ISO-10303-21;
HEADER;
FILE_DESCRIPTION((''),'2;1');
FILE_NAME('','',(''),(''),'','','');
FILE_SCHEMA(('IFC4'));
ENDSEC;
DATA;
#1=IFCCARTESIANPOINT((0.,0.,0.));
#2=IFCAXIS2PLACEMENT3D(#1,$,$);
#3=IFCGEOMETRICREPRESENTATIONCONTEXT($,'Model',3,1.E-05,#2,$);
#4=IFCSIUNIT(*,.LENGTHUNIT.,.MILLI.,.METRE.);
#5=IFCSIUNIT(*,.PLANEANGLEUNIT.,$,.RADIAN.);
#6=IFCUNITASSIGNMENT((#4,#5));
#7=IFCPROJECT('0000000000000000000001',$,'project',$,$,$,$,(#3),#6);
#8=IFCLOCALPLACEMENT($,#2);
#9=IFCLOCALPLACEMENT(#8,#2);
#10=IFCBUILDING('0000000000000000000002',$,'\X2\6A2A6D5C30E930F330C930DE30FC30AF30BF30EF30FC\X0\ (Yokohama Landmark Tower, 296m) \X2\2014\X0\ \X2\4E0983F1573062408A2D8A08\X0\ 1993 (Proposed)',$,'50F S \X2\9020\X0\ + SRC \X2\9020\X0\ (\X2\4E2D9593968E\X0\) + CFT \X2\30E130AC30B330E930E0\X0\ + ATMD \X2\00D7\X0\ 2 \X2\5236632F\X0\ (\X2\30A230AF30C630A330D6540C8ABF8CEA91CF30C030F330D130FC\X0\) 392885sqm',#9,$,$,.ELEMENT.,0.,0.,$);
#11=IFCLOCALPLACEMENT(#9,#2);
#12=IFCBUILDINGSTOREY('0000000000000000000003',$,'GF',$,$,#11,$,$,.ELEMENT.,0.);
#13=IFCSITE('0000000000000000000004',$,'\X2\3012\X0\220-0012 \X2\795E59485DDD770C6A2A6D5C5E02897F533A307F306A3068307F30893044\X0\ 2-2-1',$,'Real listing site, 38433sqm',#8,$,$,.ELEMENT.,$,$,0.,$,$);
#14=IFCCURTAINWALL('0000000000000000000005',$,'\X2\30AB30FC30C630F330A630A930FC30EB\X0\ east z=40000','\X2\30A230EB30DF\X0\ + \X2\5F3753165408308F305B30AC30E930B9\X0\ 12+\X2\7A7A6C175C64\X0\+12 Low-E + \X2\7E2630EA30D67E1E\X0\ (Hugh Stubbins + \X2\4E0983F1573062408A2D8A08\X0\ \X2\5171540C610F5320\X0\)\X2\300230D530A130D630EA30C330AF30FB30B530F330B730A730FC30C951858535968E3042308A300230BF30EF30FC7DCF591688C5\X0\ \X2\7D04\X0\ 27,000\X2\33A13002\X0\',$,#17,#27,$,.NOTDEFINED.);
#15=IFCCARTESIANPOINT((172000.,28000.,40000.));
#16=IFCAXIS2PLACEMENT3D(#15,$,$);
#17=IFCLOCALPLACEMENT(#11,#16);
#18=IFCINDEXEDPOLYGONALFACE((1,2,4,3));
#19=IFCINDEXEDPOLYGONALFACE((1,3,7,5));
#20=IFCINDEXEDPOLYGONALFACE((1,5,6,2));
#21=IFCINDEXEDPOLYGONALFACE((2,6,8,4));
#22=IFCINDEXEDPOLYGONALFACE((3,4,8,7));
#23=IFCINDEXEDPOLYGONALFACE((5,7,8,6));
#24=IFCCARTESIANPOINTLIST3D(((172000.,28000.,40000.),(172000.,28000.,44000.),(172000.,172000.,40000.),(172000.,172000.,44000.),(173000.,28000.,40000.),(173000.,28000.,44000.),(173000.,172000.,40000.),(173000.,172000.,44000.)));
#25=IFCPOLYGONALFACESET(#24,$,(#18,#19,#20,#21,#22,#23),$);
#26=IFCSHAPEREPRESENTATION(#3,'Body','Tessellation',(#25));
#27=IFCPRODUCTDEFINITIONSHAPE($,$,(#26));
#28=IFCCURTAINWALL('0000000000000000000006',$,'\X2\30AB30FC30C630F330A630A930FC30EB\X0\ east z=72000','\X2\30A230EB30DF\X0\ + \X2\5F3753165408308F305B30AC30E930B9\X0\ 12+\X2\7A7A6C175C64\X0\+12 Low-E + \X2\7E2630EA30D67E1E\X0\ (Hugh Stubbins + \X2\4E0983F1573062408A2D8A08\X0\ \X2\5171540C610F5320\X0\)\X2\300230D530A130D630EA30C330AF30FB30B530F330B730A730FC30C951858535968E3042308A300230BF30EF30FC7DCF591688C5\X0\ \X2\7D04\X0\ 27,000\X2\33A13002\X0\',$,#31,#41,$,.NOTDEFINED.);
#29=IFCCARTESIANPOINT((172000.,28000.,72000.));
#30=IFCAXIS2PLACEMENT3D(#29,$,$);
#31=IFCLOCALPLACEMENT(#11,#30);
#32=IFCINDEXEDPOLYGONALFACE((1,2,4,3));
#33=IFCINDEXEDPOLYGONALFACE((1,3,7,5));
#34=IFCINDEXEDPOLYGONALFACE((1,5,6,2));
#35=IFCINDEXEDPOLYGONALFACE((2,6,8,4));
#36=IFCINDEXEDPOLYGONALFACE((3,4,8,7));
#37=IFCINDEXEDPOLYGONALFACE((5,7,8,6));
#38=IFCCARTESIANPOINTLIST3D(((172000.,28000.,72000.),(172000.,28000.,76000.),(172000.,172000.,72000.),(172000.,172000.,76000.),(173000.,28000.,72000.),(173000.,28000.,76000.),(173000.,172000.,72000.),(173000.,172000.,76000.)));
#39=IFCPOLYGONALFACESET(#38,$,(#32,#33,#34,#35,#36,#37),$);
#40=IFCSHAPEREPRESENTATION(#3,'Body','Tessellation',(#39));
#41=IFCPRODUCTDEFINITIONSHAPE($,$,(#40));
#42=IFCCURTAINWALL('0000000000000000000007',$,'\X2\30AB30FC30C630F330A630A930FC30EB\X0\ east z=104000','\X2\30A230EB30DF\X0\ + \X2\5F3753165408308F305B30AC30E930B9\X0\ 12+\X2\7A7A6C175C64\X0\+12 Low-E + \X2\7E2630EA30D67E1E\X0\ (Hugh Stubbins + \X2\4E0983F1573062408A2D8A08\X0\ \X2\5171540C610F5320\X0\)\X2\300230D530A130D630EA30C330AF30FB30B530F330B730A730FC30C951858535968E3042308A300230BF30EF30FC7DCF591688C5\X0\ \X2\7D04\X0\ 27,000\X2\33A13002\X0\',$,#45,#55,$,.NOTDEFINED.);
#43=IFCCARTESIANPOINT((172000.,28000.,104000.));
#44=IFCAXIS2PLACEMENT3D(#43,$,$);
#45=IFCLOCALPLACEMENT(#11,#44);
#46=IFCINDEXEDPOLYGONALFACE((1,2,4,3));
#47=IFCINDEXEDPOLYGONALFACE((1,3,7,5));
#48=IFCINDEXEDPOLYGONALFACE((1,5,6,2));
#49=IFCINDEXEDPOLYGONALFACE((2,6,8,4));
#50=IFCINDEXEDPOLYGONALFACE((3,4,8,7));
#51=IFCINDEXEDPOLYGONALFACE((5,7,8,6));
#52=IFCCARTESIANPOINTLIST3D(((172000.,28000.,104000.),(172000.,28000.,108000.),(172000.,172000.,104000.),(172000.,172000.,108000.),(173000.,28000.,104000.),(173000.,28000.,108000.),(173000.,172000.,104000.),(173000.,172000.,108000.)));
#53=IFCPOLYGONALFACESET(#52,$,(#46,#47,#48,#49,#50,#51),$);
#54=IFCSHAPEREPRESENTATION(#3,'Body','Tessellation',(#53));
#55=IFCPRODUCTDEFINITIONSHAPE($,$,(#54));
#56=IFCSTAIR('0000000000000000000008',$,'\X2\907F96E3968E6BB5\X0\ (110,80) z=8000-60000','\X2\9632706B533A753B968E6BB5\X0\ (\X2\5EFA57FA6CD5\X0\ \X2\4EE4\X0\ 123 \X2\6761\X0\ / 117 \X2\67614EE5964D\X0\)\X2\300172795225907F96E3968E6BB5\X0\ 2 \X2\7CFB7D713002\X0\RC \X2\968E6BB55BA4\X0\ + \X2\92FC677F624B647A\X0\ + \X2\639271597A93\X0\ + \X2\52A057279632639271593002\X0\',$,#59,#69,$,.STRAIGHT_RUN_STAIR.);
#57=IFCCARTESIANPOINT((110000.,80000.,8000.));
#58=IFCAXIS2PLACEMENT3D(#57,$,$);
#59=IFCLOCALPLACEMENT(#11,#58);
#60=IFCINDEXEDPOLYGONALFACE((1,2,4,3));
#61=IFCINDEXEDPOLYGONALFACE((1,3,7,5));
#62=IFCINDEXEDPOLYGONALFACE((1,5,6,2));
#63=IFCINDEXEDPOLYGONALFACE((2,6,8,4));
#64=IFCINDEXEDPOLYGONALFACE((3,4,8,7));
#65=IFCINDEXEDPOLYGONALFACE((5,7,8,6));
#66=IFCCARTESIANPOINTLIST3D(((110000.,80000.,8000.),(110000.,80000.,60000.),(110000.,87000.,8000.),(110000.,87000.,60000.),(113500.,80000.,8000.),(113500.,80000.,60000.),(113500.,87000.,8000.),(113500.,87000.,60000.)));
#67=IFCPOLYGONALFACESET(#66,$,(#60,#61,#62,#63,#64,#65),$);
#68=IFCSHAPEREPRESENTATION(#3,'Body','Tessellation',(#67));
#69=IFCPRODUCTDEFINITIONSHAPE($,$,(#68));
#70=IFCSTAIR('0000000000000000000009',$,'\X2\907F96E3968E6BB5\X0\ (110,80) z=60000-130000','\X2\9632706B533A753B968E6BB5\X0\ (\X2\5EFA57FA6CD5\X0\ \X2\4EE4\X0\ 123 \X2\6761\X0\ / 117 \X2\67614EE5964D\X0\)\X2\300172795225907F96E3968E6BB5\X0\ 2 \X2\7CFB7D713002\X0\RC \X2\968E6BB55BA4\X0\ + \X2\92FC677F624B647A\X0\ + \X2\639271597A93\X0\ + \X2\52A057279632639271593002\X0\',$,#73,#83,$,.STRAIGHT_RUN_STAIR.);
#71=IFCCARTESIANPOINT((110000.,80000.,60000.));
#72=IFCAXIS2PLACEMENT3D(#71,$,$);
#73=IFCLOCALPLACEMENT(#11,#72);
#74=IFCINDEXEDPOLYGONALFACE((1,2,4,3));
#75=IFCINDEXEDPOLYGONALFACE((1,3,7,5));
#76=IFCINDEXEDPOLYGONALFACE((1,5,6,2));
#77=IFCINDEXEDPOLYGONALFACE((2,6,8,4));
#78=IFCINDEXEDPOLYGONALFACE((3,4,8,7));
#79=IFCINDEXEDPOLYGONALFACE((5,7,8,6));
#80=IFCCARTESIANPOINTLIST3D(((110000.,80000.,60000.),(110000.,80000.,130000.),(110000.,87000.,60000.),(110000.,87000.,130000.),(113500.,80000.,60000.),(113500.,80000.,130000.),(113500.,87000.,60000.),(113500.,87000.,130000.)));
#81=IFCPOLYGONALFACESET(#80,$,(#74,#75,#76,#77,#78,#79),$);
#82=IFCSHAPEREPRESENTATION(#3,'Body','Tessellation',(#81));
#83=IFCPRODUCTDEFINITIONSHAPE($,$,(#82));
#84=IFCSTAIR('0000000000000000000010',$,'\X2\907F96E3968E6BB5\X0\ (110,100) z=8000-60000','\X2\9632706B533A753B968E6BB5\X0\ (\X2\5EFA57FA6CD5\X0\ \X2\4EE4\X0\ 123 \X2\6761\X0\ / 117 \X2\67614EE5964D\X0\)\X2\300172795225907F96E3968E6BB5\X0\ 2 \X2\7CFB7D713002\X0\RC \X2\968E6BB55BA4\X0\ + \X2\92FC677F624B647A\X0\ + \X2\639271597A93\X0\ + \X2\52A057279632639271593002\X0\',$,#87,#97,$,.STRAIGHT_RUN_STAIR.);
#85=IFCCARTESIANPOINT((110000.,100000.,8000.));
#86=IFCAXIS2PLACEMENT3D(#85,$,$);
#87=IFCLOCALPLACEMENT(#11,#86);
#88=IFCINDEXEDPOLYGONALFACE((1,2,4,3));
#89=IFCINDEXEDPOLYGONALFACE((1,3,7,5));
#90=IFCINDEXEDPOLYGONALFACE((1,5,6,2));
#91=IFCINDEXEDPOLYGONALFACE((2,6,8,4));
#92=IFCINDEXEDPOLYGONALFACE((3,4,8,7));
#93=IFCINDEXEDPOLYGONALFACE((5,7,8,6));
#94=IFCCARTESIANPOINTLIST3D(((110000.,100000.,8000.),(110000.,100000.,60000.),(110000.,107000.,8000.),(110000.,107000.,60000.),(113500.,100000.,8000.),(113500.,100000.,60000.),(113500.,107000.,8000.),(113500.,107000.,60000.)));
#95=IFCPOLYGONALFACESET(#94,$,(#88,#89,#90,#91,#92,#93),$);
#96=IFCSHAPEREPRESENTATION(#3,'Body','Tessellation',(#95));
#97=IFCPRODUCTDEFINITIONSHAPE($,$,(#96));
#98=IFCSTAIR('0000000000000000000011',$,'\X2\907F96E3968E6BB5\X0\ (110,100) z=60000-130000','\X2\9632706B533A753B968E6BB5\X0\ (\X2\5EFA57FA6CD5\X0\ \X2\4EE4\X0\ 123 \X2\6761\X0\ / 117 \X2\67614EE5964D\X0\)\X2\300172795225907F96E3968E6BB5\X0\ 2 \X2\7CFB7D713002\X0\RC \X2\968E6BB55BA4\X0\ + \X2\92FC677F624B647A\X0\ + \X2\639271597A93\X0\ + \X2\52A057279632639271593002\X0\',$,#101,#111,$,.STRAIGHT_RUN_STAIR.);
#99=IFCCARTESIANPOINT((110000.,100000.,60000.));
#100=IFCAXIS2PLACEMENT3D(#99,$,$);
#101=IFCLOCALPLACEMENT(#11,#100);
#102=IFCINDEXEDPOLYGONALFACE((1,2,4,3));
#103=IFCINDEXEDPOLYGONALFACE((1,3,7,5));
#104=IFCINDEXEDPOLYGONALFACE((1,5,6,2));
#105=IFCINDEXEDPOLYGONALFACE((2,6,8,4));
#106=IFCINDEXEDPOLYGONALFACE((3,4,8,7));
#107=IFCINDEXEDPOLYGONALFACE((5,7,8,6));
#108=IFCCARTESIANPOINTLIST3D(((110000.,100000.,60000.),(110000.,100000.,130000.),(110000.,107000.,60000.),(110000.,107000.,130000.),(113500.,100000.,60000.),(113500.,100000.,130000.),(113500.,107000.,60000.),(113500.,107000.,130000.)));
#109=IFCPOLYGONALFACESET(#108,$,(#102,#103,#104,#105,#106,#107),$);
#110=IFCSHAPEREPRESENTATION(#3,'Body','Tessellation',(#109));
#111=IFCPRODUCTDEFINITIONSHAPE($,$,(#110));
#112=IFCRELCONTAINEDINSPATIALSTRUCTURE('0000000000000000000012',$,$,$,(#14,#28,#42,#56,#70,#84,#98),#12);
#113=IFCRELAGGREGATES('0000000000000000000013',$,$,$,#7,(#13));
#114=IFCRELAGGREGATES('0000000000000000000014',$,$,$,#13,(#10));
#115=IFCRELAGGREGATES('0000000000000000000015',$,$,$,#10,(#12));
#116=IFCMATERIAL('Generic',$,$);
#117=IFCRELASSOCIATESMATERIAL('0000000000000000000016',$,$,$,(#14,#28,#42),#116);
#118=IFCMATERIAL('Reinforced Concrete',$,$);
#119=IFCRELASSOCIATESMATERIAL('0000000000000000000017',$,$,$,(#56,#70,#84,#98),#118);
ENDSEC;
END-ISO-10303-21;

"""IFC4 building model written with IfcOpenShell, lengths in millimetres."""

from ifc_helpers import new_model, si_unit, frame, frame_2d, origin, place, context, project, spatial, rectangle, extrude, material, element, save


model = new_model("IFC4")

# Units and contexts
model_context = context("Model", 3, precision=1e-05, world=origin())
ifc_project = project(units=[si_unit("LENGTHUNIT", "METRE", prefix="MILLI"), si_unit("PLANEANGLEUNIT", "RADIAN")], contexts=[model_context])

# Site, building, storey
site_placement = place(None, origin())
site = spatial("IfcSite", under=ifc_project, at=site_placement, Name="〒220-0012 神奈川県横浜市西区みなとみらい 2-2-1", ObjectType="Real listing site, 38433sqm", CompositionType="ELEMENT", RefElevation=0.0)
building_placement = place(site_placement, origin())
building = spatial("IfcBuilding", under=site, at=building_placement, Name="横浜ランドマークタワー (Yokohama Landmark Tower, 296m) — 三菱地所設計 1993 (Proposed)", ObjectType="50F S 造 + SRC 造 (中間階) + CFT メガコラム + ATMD × 2 制振 (アクティブ同調質量ダンパー) 392885sqm", CompositionType="ELEMENT", ElevationOfRefHeight=0.0, ElevationOfTerrain=0.0)
storey_placement = place(building_placement, origin())
storey = spatial("IfcBuildingStorey", under=building, at=storey_placement, Name="GF", CompositionType="ELEMENT", Elevation=0.0)

# Shared definitions
ifc_material_1 = material(Name="Reinforced Concrete")

# Shared definitions
ifc_material_2 = material(Name="Generic")

# Curtain walls
curtain_wall_1_placement = place(storey_placement, frame((172000.0, 28000.0, 40000.0)))
element("IfcCurtainWall", 1, at=curtain_wall_1_placement, inside=storey, material=ifc_material_2, Name="カーテンウォール east z=40000", Description="アルミ + 強化合わせガラス 12+空気層+12 Low-E + 縦リブ縞 (Hugh Stubbins + 三菱地所設計 共同意匠)。ファブリック・サンシェード内蔵階あり。タワー総外装 約 27,000㎡。", PredefinedType="NOTDEFINED", context=model_context, shape_type="SweptSolid", body=[
    extrude(rectangle(XDim=1000.0, YDim=144000.0, at=frame_2d((500.0, 72000.0))), frame((172000.0, 28000.0, 40000.0)), (0.0, 0.0, 1.0), 4000.0),
])
curtain_wall_2_placement = place(storey_placement, frame((172000.0, 28000.0, 72000.0)))
element("IfcCurtainWall", 2, at=curtain_wall_2_placement, inside=storey, material=ifc_material_2, Name="カーテンウォール east z=72000", Description="アルミ + 強化合わせガラス 12+空気層+12 Low-E + 縦リブ縞 (Hugh Stubbins + 三菱地所設計 共同意匠)。ファブリック・サンシェード内蔵階あり。タワー総外装 約 27,000㎡。", PredefinedType="NOTDEFINED", context=model_context, shape_type="SweptSolid", body=[
    extrude(rectangle(XDim=1000.0, YDim=144000.0, at=frame_2d((500.0, 72000.0))), frame((172000.0, 28000.0, 72000.0)), (0.0, 0.0, 1.0), 4000.0),
])
curtain_wall_3_placement = place(storey_placement, frame((172000.0, 28000.0, 104000.0)))
element("IfcCurtainWall", 3, at=curtain_wall_3_placement, inside=storey, material=ifc_material_2, Name="カーテンウォール east z=104000", Description="アルミ + 強化合わせガラス 12+空気層+12 Low-E + 縦リブ縞 (Hugh Stubbins + 三菱地所設計 共同意匠)。ファブリック・サンシェード内蔵階あり。タワー総外装 約 27,000㎡。", PredefinedType="NOTDEFINED", context=model_context, shape_type="SweptSolid", body=[
    extrude(rectangle(XDim=1000.0, YDim=144000.0, at=frame_2d((500.0, 72000.0))), frame((172000.0, 28000.0, 104000.0)), (0.0, 0.0, 1.0), 4000.0),
])

# Stairs
stair_1_placement = place(storey_placement, frame((110000.0, 80000.0, 8000.0)))
element("IfcStair", 4, at=stair_1_placement, inside=storey, material=ifc_material_1, Name="避難階段 (110,80) z=8000-60000", Description="防火区画階段 (建基法 令 123 条 / 117 条以降)、特別避難階段 2 系統。RC 階段室 + 鋼板手摺 + 排煙窓 + 加圧防排煙。", PredefinedType="STRAIGHT_RUN_STAIR", context=model_context, shape_type="SweptSolid", body=[
    extrude(rectangle(XDim=3500.0, YDim=7000.0, at=frame_2d((1750.0, 3500.0))), frame((110000.0, 80000.0, 8000.0)), (0.0, 0.0, 1.0), 52000.0),
])
stair_2_placement = place(storey_placement, frame((110000.0, 80000.0, 60000.0)))
element("IfcStair", 5, at=stair_2_placement, inside=storey, material=ifc_material_1, Name="避難階段 (110,80) z=60000-130000", Description="防火区画階段 (建基法 令 123 条 / 117 条以降)、特別避難階段 2 系統。RC 階段室 + 鋼板手摺 + 排煙窓 + 加圧防排煙。", PredefinedType="STRAIGHT_RUN_STAIR", context=model_context, shape_type="SweptSolid", body=[
    extrude(rectangle(XDim=3500.0, YDim=7000.0, at=frame_2d((1750.0, 3500.0))), frame((110000.0, 80000.0, 60000.0)), (0.0, 0.0, 1.0), 70000.0),
])
stair_3_placement = place(storey_placement, frame((110000.0, 100000.0, 8000.0)))
element("IfcStair", 6, at=stair_3_placement, inside=storey, material=ifc_material_1, Name="避難階段 (110,100) z=8000-60000", Description="防火区画階段 (建基法 令 123 条 / 117 条以降)、特別避難階段 2 系統。RC 階段室 + 鋼板手摺 + 排煙窓 + 加圧防排煙。", PredefinedType="STRAIGHT_RUN_STAIR", context=model_context, shape_type="SweptSolid", body=[
    extrude(rectangle(XDim=3500.0, YDim=7000.0, at=frame_2d((1750.0, 3500.0))), frame((110000.0, 100000.0, 8000.0)), (0.0, 0.0, 1.0), 52000.0),
])
stair_4_placement = place(storey_placement, frame((110000.0, 100000.0, 60000.0)))
element("IfcStair", 7, at=stair_4_placement, inside=storey, material=ifc_material_1, Name="避難階段 (110,100) z=60000-130000", Description="防火区画階段 (建基法 令 123 条 / 117 条以降)、特別避難階段 2 系統。RC 階段室 + 鋼板手摺 + 排煙窓 + 加圧防排煙。", PredefinedType="STRAIGHT_RUN_STAIR", context=model_context, shape_type="SweptSolid", body=[
    extrude(rectangle(XDim=3500.0, YDim=7000.0, at=frame_2d((1750.0, 3500.0))), frame((110000.0, 100000.0, 60000.0)), (0.0, 0.0, 1.0), 70000.0),
])

save(model, "model.ifc")
